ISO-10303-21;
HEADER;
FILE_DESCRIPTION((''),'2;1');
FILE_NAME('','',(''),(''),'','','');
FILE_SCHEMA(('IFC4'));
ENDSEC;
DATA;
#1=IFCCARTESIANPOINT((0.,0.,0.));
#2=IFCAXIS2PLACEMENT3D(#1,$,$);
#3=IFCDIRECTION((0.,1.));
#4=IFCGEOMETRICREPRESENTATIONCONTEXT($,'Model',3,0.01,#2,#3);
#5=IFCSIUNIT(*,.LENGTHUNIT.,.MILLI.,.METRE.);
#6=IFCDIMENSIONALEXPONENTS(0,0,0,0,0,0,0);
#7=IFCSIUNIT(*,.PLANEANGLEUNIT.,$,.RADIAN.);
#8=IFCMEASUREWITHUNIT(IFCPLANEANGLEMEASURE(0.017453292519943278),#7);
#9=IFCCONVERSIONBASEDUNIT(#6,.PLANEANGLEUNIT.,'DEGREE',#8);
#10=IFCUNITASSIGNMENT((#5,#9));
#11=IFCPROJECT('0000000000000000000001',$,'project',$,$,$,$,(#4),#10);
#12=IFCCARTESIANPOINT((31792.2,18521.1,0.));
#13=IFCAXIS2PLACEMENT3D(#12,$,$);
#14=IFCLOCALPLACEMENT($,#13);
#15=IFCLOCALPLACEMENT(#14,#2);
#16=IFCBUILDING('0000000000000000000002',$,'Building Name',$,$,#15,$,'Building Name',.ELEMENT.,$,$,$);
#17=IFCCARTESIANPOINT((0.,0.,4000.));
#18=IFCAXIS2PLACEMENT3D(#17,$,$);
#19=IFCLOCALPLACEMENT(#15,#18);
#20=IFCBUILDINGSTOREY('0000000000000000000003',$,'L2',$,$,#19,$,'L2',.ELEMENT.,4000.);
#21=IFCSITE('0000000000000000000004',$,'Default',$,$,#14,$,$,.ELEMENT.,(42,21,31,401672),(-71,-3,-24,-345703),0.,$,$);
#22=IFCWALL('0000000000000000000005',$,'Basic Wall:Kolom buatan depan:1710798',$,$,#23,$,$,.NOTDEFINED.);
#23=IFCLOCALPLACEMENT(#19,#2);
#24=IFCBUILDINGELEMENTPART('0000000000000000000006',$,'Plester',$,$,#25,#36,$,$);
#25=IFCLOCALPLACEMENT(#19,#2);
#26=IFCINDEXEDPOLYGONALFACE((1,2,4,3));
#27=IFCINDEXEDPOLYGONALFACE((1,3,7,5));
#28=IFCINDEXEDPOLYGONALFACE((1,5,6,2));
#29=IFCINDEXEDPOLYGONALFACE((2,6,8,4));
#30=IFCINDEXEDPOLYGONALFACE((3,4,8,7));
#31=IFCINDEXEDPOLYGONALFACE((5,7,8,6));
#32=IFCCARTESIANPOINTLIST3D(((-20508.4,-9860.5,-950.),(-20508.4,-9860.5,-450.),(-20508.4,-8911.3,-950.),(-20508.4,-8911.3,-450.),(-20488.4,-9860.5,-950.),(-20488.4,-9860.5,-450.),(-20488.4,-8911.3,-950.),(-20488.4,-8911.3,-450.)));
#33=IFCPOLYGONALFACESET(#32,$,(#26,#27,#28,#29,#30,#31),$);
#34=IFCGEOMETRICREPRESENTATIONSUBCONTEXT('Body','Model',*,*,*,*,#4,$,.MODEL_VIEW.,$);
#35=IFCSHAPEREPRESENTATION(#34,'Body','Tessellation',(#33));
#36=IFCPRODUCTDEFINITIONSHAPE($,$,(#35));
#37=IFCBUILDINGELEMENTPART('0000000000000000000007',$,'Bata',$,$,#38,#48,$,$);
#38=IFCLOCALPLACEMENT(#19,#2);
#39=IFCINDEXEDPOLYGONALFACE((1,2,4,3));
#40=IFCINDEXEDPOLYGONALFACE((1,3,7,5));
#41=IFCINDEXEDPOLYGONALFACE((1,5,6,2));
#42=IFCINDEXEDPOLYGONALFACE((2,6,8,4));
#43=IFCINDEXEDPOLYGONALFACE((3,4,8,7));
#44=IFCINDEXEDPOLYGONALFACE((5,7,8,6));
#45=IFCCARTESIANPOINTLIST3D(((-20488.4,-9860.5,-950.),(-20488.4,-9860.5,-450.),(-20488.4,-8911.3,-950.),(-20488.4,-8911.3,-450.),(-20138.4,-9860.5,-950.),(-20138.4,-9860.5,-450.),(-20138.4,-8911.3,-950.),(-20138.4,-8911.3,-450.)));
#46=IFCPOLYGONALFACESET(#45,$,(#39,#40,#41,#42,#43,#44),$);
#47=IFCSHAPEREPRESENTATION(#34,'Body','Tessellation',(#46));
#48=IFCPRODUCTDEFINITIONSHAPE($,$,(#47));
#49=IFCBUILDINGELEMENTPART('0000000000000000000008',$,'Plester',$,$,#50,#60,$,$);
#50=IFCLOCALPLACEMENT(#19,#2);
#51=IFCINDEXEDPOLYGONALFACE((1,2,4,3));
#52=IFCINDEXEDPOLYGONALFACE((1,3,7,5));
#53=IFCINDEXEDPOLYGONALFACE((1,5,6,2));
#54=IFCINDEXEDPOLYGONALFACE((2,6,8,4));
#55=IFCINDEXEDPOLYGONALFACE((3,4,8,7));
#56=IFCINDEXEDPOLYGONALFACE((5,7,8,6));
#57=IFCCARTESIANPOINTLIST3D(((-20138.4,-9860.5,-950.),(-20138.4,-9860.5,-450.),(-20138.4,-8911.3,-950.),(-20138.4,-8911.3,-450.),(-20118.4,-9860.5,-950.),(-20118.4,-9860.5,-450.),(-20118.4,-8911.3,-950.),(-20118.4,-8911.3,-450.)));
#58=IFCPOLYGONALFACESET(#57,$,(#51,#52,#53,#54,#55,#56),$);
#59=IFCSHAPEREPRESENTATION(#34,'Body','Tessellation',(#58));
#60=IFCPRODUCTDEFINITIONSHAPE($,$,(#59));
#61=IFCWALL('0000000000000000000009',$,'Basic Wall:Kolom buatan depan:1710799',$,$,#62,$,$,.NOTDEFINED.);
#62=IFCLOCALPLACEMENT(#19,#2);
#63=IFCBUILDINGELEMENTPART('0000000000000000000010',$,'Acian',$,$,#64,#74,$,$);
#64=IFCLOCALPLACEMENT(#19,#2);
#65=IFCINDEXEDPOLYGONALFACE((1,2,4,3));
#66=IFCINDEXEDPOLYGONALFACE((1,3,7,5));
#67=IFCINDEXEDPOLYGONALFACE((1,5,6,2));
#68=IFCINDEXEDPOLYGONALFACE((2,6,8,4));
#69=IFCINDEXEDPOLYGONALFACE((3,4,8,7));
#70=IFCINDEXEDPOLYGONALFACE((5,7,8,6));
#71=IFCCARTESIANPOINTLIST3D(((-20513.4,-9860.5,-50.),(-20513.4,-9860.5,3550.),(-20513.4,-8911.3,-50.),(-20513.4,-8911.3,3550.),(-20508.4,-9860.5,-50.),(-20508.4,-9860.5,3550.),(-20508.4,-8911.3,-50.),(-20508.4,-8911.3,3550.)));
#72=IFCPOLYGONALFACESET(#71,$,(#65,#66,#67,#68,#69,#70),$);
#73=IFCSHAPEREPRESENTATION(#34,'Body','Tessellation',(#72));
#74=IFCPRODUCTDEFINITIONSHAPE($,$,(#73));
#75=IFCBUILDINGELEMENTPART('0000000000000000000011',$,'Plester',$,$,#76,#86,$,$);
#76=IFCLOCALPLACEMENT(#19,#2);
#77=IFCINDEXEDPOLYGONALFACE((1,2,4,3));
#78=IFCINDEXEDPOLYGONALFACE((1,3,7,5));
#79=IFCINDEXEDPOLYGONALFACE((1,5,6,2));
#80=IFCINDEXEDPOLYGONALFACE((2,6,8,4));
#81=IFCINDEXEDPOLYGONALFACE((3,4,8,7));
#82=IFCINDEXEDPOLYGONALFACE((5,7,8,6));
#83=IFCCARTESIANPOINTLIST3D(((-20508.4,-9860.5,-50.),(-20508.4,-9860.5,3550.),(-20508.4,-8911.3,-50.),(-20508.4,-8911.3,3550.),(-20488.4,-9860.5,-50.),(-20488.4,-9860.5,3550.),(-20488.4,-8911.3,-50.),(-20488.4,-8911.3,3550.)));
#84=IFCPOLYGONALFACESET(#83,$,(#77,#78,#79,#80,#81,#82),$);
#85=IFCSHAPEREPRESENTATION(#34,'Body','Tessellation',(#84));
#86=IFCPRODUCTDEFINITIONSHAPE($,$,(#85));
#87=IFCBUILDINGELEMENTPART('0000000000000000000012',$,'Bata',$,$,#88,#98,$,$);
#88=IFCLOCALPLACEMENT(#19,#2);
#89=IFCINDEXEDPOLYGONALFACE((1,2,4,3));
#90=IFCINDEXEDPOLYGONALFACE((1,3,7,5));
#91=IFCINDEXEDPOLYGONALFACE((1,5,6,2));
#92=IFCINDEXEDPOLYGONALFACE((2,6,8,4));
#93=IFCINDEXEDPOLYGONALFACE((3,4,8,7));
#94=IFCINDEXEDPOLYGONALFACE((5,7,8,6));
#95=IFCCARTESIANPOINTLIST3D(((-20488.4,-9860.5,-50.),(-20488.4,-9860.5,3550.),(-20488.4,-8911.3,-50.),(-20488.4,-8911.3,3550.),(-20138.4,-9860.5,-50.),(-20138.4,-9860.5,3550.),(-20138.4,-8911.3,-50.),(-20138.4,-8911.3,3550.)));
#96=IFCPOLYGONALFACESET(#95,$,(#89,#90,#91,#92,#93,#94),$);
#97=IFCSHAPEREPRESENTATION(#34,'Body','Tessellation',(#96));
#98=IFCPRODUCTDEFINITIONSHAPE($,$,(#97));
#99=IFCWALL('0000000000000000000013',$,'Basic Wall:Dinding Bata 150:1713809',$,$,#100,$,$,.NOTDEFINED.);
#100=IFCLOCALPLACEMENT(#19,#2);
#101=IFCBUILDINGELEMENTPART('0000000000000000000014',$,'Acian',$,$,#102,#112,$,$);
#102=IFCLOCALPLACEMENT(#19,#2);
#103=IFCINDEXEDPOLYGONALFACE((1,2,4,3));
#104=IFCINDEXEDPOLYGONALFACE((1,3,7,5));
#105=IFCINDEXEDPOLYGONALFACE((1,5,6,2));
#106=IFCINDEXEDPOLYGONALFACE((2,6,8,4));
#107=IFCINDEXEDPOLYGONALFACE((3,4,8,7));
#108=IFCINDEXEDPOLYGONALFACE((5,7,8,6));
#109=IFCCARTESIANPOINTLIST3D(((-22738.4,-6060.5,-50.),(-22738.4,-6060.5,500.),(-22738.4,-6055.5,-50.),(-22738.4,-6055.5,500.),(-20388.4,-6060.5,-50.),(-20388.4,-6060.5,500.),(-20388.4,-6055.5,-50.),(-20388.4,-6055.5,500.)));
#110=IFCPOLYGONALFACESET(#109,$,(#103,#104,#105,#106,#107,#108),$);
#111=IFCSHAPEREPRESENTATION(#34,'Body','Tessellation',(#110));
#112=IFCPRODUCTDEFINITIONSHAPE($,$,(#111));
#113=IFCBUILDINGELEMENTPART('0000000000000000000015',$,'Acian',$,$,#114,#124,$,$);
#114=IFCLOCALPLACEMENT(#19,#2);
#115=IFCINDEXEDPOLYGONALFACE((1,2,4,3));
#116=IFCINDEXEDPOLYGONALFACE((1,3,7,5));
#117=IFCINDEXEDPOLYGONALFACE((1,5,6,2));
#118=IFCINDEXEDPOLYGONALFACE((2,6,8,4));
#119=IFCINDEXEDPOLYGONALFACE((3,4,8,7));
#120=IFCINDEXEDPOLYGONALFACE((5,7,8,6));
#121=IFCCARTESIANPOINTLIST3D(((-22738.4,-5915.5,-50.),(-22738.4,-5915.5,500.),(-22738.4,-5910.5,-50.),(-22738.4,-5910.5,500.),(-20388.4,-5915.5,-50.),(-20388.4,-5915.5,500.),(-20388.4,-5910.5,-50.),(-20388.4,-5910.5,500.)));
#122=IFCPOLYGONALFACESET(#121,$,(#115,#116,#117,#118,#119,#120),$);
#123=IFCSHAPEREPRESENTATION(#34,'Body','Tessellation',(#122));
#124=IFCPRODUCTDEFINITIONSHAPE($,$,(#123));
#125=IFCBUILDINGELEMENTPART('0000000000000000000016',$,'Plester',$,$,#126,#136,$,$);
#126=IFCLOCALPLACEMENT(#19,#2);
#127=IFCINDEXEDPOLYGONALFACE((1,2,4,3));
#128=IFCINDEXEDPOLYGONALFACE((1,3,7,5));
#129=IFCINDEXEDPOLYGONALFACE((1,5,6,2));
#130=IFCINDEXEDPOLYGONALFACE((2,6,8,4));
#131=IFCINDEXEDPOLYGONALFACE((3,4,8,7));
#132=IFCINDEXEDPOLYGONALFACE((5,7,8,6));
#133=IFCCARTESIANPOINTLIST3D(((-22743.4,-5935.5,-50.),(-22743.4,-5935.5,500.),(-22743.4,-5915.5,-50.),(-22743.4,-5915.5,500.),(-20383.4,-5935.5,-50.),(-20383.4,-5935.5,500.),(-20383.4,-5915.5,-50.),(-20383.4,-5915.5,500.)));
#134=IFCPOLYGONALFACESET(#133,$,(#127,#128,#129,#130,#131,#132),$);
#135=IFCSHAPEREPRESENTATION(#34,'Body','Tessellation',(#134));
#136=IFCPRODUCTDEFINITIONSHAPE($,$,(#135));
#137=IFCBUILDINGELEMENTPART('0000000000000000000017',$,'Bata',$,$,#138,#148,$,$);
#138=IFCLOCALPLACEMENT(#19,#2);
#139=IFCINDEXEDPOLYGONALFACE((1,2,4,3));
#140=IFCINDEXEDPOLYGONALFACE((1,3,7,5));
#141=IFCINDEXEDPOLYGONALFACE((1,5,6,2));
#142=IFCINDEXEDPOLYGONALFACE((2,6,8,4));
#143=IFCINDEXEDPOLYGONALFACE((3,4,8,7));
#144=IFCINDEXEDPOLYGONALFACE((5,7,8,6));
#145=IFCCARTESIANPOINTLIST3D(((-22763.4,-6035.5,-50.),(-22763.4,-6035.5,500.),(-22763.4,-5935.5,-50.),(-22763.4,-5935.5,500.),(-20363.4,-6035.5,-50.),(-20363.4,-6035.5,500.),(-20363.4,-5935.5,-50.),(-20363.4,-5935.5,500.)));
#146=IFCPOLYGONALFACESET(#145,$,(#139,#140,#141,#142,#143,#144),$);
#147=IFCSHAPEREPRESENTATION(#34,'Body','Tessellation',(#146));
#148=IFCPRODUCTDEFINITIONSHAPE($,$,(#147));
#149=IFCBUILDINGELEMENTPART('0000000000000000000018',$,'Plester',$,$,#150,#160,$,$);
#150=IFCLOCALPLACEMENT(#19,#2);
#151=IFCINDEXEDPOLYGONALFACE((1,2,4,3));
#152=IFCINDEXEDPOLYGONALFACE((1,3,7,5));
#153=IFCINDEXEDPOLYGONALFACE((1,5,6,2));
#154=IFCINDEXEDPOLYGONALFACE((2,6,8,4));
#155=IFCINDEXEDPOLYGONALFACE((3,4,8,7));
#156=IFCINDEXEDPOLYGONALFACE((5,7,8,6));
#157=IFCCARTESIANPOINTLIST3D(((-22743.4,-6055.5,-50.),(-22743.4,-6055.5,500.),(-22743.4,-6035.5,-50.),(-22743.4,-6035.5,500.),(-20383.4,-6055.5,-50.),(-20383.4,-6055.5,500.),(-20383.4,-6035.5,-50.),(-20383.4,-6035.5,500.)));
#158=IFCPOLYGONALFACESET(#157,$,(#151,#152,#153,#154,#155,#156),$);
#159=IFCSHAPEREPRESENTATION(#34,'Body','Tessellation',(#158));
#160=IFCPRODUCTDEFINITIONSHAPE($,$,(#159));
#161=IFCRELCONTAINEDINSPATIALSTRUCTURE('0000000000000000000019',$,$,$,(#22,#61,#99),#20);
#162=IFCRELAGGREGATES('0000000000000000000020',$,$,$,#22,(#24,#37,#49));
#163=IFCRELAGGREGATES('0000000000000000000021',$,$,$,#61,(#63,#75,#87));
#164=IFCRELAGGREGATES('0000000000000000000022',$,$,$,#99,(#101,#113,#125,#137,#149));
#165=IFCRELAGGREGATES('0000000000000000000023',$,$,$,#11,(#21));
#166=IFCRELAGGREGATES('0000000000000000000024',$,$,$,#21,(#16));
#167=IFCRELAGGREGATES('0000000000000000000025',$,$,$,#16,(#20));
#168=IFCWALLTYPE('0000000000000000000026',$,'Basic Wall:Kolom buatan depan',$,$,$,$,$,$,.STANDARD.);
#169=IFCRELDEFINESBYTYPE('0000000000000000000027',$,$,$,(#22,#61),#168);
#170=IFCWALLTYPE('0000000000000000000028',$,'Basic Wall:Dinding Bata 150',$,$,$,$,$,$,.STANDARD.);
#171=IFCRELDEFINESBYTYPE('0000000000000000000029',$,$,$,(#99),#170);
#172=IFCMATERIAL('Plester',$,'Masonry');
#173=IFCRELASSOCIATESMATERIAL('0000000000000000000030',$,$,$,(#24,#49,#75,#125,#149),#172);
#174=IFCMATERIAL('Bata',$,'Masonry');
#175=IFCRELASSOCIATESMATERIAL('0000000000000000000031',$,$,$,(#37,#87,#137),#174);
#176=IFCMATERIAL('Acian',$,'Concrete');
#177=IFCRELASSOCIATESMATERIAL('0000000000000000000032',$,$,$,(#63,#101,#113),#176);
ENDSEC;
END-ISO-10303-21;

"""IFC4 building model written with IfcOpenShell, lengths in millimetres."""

from ifc_helpers import new_model, entity, si_unit, converted_unit, direction, frame, origin, place, context, subcontext, project, spatial, indexed_curve, outline, extrude, material, type_object, element, aggregate, save


model = new_model("IFC4")

# Units and contexts
model_context = context("Model", 3, precision=0.01, world=origin(), true_north=direction((0.0, 1.0)))
body_context = subcontext(model_context, "Body", "Model", "MODEL_VIEW")
ifc_project = project(units=[si_unit("LENGTHUNIT", "METRE", prefix="MILLI"), converted_unit("PLANEANGLEUNIT", "DEGREE", entity("IfcPlaneAngleMeasure", 0.017453292519943278), si_unit("PLANEANGLEUNIT", "RADIAN"), dimensions=[0, 0, 0, 0, 0, 0, 0])], contexts=[model_context])

# Site, building, storey
site_placement = place(None, frame((31792.2, 18521.1, 0.0)))
site = spatial("IfcSite", under=ifc_project, at=site_placement, Name="Default", CompositionType="ELEMENT", RefLatitude=(42, 21, 31, 401672), RefLongitude=(-71, -3, -24, -345703), RefElevation=0.0)
building_placement = place(site_placement, origin())
building = spatial("IfcBuilding", under=site, at=building_placement, Name="Building Name", LongName="Building Name", CompositionType="ELEMENT")
storey_placement = place(building_placement, frame((0.0, 0.0, 4000.0)))
storey = spatial("IfcBuildingStorey", under=building, at=storey_placement, Name="L2", LongName="L2", CompositionType="ELEMENT", Elevation=4000.0)

# Shared definitions
wall_type_1 = type_object("IfcWallType", Name="Basic Wall:Dinding Bata 150", PredefinedType="STANDARD")
ifc_material_1 = material(Name="Acian", Category="Concrete")

# Walls, building element parts
ifc_material_2 = material(Name="Plester", Category="Masonry")
ifc_material_3 = material(Name="Bata", Category="Masonry")
wall_type_2 = type_object("IfcWallType", Name="Basic Wall:Kolom buatan depan", PredefinedType="STANDARD")
wall_1_placement = place(storey_placement, frame((-20313.4, -8911.3, -950.0), z_axis=(0.0, 0.0, 1.0), x_axis=(0.0, -1.0, 0.0)))
wall_1 = element("IfcWall", 1, at=wall_1_placement, inside=storey, type_object=wall_type_2, Name="Basic Wall:Kolom buatan depan:1710798", PredefinedType="NOTDEFINED")
building_element_part_1_placement = place(wall_1_placement, origin())
building_element_part_1 = element("IfcBuildingElementPart", 2, at=building_element_part_1_placement, material=ifc_material_2, Name="Plester", context=body_context, shape_type="SweptSolid", body=[
    extrude(outline(indexed_curve([(-474.6, -10.0), (474.6, -10.0), (474.6, 10.0), (-474.6, 10.0), (-474.6, -10.0)], self_intersect=False)), frame((474.6, -185.0, 0.0)), (0.0, 0.0, 1.0), 500.0),
])
building_element_part_2_placement = place(wall_1_placement, origin())
building_element_part_2 = element("IfcBuildingElementPart", 3, at=building_element_part_2_placement, material=ifc_material_3, Name="Bata", context=body_context, shape_type="SweptSolid", body=[
    extrude(outline(indexed_curve([(-474.6, -175.0), (474.6, -175.0), (474.6, 175.0), (-474.6, 175.0), (-474.6, -175.0)], self_intersect=False)), frame((474.6, 0.0, 0.0)), (0.0, 0.0, 1.0), 500.0),
])
building_element_part_3_placement = place(wall_1_placement, origin())
building_element_part_3 = element("IfcBuildingElementPart", 4, at=building_element_part_3_placement, material=ifc_material_2, Name="Plester", context=body_context, shape_type="SweptSolid", body=[
    extrude(outline(indexed_curve([(-474.6, -10.0), (474.6, -10.0), (474.6, 10.0), (-474.6, 10.0), (-474.6, -10.0)], self_intersect=False)), frame((474.6, 185.0, 0.0)), (0.0, 0.0, 1.0), 500.0),
])
aggregate(wall_1, [building_element_part_1, building_element_part_2, building_element_part_3])
wall_2_placement = place(storey_placement, frame((-20313.4, -8911.3, -50.0), z_axis=(0.0, 0.0, 1.0), x_axis=(0.0, -1.0, 0.0)))
wall_2 = element("IfcWall", 5, at=wall_2_placement, inside=storey, type_object=wall_type_2, Name="Basic Wall:Kolom buatan depan:1710799", PredefinedType="NOTDEFINED")
building_element_part_4_placement = place(wall_2_placement, origin())
building_element_part_4 = element("IfcBuildingElementPart", 6, at=building_element_part_4_placement, material=ifc_material_1, Name="Acian", context=body_context, shape_type="SweptSolid", body=[
    extrude(outline(indexed_curve([(-474.6, -2.5), (474.6, -2.5), (474.6, 2.5), (-474.6, 2.5), (-474.6, -2.5)], self_intersect=False)), frame((474.6, -197.5, 0.0)), (0.0, 0.0, 1.0), 3600.0),
])
building_element_part_5_placement = place(wall_2_placement, origin())
building_element_part_5 = element("IfcBuildingElementPart", 7, at=building_element_part_5_placement, material=ifc_material_2, Name="Plester", context=body_context, shape_type="SweptSolid", body=[
    extrude(outline(indexed_curve([(-474.6, -10.0), (474.6, -10.0), (474.6, 10.0), (-474.6, 10.0), (-474.6, -10.0)], self_intersect=False)), frame((474.6, -185.0, 0.0)), (0.0, 0.0, 1.0), 3600.0),
])
building_element_part_6_placement = place(wall_2_placement, origin())
building_element_part_6 = element("IfcBuildingElementPart", 8, at=building_element_part_6_placement, material=ifc_material_3, Name="Bata", context=body_context, shape_type="SweptSolid", body=[
    extrude(outline(indexed_curve([(-474.6, -175.0), (474.6, -175.0), (474.6, 175.0), (-474.6, 175.0), (-474.6, -175.0)], self_intersect=False)), frame((474.6, 0.0, 0.0)), (0.0, 0.0, 1.0), 3600.0),
])
aggregate(wall_2, [building_element_part_4, building_element_part_5, building_element_part_6])
wall_3_placement = place(storey_placement, frame((-22738.4, -5985.5, -50.0)))
wall_3 = element("IfcWall", 9, at=wall_3_placement, inside=storey, type_object=wall_type_1, Name="Basic Wall:Dinding Bata 150:1713809", PredefinedType="NOTDEFINED")
building_element_part_7_placement = place(wall_3_placement, origin())
building_element_part_7 = element("IfcBuildingElementPart", 10, at=building_element_part_7_placement, material=ifc_material_1, Name="Acian", context=body_context, shape_type="SweptSolid", body=[
    extrude(outline(indexed_curve([(-2.5, -1175.0), (2.5, -1175.0), (2.5, 1175.0), (-2.5, 1175.0), (-2.5, -1175.0)], self_intersect=False)), frame((1175.0, -72.5, 0.0), z_axis=(0.0, 0.0, 1.0), x_axis=(0.0, -1.0, 0.0)), (0.0, 0.0, 1.0), 550.0),
])
building_element_part_8_placement = place(wall_3_placement, origin())
building_element_part_8 = element("IfcBuildingElementPart", 11, at=building_element_part_8_placement, material=ifc_material_1, Name="Acian", context=body_context, shape_type="SweptSolid", body=[
    extrude(outline(indexed_curve([(-2.5, -1175.0), (2.5, -1175.0), (2.5, 1175.0), (-2.5, 1175.0), (-2.5, -1175.0)], self_intersect=False)), frame((1175.0, 72.5, 0.0), z_axis=(0.0, 0.0, 1.0), x_axis=(0.0, -1.0, 0.0)), (0.0, 0.0, 1.0), 550.0),
])
building_element_part_9_placement = place(wall_3_placement, origin())
building_element_part_9 = element("IfcBuildingElementPart", 12, at=building_element_part_9_placement, material=ifc_material_2, Name="Plester", context=body_context, shape_type="SweptSolid", body=[
    extrude(outline(indexed_curve([(-10.0, -1180.0), (10.0, -1180.0), (10.0, 1180.0), (-10.0, 1180.0), (-10.0, -1180.0)], self_intersect=False)), frame((1175.0, 60.0, 0.0), z_axis=(0.0, 0.0, 1.0), x_axis=(0.0, -1.0, 0.0)), (0.0, 0.0, 1.0), 550.0),
])
building_element_part_10_placement = place(wall_3_placement, origin())
building_element_part_10 = element("IfcBuildingElementPart", 13, at=building_element_part_10_placement, material=ifc_material_3, Name="Bata", context=body_context, shape_type="SweptSolid", body=[
    extrude(outline(indexed_curve([(-50.0, -1200.0), (50.0, -1200.0), (50.0, 1200.0), (-50.0, 1200.0), (-50.0, -1200.0)], self_intersect=False)), frame((1175.0, 0.0, 0.0), z_axis=(0.0, 0.0, 1.0), x_axis=(0.0, -1.0, 0.0)), (0.0, 0.0, 1.0), 550.0),
])
building_element_part_11_placement = place(wall_3_placement, origin())
building_element_part_11 = element("IfcBuildingElementPart", 14, at=building_element_part_11_placement, material=ifc_material_2, Name="Plester", context=body_context, shape_type="SweptSolid", body=[
    extrude(outline(indexed_curve([(-10.0, -1180.0), (10.0, -1180.0), (10.0, 1180.0), (-10.0, 1180.0), (-10.0, -1180.0)], self_intersect=False)), frame((1175.0, -60.0, 0.0), z_axis=(0.0, 0.0, 1.0), x_axis=(0.0, -1.0, 0.0)), (0.0, 0.0, 1.0), 550.0),
])
aggregate(wall_3, [building_element_part_7, building_element_part_8, building_element_part_9, building_element_part_10, building_element_part_11])

save(model, "model.ifc")
